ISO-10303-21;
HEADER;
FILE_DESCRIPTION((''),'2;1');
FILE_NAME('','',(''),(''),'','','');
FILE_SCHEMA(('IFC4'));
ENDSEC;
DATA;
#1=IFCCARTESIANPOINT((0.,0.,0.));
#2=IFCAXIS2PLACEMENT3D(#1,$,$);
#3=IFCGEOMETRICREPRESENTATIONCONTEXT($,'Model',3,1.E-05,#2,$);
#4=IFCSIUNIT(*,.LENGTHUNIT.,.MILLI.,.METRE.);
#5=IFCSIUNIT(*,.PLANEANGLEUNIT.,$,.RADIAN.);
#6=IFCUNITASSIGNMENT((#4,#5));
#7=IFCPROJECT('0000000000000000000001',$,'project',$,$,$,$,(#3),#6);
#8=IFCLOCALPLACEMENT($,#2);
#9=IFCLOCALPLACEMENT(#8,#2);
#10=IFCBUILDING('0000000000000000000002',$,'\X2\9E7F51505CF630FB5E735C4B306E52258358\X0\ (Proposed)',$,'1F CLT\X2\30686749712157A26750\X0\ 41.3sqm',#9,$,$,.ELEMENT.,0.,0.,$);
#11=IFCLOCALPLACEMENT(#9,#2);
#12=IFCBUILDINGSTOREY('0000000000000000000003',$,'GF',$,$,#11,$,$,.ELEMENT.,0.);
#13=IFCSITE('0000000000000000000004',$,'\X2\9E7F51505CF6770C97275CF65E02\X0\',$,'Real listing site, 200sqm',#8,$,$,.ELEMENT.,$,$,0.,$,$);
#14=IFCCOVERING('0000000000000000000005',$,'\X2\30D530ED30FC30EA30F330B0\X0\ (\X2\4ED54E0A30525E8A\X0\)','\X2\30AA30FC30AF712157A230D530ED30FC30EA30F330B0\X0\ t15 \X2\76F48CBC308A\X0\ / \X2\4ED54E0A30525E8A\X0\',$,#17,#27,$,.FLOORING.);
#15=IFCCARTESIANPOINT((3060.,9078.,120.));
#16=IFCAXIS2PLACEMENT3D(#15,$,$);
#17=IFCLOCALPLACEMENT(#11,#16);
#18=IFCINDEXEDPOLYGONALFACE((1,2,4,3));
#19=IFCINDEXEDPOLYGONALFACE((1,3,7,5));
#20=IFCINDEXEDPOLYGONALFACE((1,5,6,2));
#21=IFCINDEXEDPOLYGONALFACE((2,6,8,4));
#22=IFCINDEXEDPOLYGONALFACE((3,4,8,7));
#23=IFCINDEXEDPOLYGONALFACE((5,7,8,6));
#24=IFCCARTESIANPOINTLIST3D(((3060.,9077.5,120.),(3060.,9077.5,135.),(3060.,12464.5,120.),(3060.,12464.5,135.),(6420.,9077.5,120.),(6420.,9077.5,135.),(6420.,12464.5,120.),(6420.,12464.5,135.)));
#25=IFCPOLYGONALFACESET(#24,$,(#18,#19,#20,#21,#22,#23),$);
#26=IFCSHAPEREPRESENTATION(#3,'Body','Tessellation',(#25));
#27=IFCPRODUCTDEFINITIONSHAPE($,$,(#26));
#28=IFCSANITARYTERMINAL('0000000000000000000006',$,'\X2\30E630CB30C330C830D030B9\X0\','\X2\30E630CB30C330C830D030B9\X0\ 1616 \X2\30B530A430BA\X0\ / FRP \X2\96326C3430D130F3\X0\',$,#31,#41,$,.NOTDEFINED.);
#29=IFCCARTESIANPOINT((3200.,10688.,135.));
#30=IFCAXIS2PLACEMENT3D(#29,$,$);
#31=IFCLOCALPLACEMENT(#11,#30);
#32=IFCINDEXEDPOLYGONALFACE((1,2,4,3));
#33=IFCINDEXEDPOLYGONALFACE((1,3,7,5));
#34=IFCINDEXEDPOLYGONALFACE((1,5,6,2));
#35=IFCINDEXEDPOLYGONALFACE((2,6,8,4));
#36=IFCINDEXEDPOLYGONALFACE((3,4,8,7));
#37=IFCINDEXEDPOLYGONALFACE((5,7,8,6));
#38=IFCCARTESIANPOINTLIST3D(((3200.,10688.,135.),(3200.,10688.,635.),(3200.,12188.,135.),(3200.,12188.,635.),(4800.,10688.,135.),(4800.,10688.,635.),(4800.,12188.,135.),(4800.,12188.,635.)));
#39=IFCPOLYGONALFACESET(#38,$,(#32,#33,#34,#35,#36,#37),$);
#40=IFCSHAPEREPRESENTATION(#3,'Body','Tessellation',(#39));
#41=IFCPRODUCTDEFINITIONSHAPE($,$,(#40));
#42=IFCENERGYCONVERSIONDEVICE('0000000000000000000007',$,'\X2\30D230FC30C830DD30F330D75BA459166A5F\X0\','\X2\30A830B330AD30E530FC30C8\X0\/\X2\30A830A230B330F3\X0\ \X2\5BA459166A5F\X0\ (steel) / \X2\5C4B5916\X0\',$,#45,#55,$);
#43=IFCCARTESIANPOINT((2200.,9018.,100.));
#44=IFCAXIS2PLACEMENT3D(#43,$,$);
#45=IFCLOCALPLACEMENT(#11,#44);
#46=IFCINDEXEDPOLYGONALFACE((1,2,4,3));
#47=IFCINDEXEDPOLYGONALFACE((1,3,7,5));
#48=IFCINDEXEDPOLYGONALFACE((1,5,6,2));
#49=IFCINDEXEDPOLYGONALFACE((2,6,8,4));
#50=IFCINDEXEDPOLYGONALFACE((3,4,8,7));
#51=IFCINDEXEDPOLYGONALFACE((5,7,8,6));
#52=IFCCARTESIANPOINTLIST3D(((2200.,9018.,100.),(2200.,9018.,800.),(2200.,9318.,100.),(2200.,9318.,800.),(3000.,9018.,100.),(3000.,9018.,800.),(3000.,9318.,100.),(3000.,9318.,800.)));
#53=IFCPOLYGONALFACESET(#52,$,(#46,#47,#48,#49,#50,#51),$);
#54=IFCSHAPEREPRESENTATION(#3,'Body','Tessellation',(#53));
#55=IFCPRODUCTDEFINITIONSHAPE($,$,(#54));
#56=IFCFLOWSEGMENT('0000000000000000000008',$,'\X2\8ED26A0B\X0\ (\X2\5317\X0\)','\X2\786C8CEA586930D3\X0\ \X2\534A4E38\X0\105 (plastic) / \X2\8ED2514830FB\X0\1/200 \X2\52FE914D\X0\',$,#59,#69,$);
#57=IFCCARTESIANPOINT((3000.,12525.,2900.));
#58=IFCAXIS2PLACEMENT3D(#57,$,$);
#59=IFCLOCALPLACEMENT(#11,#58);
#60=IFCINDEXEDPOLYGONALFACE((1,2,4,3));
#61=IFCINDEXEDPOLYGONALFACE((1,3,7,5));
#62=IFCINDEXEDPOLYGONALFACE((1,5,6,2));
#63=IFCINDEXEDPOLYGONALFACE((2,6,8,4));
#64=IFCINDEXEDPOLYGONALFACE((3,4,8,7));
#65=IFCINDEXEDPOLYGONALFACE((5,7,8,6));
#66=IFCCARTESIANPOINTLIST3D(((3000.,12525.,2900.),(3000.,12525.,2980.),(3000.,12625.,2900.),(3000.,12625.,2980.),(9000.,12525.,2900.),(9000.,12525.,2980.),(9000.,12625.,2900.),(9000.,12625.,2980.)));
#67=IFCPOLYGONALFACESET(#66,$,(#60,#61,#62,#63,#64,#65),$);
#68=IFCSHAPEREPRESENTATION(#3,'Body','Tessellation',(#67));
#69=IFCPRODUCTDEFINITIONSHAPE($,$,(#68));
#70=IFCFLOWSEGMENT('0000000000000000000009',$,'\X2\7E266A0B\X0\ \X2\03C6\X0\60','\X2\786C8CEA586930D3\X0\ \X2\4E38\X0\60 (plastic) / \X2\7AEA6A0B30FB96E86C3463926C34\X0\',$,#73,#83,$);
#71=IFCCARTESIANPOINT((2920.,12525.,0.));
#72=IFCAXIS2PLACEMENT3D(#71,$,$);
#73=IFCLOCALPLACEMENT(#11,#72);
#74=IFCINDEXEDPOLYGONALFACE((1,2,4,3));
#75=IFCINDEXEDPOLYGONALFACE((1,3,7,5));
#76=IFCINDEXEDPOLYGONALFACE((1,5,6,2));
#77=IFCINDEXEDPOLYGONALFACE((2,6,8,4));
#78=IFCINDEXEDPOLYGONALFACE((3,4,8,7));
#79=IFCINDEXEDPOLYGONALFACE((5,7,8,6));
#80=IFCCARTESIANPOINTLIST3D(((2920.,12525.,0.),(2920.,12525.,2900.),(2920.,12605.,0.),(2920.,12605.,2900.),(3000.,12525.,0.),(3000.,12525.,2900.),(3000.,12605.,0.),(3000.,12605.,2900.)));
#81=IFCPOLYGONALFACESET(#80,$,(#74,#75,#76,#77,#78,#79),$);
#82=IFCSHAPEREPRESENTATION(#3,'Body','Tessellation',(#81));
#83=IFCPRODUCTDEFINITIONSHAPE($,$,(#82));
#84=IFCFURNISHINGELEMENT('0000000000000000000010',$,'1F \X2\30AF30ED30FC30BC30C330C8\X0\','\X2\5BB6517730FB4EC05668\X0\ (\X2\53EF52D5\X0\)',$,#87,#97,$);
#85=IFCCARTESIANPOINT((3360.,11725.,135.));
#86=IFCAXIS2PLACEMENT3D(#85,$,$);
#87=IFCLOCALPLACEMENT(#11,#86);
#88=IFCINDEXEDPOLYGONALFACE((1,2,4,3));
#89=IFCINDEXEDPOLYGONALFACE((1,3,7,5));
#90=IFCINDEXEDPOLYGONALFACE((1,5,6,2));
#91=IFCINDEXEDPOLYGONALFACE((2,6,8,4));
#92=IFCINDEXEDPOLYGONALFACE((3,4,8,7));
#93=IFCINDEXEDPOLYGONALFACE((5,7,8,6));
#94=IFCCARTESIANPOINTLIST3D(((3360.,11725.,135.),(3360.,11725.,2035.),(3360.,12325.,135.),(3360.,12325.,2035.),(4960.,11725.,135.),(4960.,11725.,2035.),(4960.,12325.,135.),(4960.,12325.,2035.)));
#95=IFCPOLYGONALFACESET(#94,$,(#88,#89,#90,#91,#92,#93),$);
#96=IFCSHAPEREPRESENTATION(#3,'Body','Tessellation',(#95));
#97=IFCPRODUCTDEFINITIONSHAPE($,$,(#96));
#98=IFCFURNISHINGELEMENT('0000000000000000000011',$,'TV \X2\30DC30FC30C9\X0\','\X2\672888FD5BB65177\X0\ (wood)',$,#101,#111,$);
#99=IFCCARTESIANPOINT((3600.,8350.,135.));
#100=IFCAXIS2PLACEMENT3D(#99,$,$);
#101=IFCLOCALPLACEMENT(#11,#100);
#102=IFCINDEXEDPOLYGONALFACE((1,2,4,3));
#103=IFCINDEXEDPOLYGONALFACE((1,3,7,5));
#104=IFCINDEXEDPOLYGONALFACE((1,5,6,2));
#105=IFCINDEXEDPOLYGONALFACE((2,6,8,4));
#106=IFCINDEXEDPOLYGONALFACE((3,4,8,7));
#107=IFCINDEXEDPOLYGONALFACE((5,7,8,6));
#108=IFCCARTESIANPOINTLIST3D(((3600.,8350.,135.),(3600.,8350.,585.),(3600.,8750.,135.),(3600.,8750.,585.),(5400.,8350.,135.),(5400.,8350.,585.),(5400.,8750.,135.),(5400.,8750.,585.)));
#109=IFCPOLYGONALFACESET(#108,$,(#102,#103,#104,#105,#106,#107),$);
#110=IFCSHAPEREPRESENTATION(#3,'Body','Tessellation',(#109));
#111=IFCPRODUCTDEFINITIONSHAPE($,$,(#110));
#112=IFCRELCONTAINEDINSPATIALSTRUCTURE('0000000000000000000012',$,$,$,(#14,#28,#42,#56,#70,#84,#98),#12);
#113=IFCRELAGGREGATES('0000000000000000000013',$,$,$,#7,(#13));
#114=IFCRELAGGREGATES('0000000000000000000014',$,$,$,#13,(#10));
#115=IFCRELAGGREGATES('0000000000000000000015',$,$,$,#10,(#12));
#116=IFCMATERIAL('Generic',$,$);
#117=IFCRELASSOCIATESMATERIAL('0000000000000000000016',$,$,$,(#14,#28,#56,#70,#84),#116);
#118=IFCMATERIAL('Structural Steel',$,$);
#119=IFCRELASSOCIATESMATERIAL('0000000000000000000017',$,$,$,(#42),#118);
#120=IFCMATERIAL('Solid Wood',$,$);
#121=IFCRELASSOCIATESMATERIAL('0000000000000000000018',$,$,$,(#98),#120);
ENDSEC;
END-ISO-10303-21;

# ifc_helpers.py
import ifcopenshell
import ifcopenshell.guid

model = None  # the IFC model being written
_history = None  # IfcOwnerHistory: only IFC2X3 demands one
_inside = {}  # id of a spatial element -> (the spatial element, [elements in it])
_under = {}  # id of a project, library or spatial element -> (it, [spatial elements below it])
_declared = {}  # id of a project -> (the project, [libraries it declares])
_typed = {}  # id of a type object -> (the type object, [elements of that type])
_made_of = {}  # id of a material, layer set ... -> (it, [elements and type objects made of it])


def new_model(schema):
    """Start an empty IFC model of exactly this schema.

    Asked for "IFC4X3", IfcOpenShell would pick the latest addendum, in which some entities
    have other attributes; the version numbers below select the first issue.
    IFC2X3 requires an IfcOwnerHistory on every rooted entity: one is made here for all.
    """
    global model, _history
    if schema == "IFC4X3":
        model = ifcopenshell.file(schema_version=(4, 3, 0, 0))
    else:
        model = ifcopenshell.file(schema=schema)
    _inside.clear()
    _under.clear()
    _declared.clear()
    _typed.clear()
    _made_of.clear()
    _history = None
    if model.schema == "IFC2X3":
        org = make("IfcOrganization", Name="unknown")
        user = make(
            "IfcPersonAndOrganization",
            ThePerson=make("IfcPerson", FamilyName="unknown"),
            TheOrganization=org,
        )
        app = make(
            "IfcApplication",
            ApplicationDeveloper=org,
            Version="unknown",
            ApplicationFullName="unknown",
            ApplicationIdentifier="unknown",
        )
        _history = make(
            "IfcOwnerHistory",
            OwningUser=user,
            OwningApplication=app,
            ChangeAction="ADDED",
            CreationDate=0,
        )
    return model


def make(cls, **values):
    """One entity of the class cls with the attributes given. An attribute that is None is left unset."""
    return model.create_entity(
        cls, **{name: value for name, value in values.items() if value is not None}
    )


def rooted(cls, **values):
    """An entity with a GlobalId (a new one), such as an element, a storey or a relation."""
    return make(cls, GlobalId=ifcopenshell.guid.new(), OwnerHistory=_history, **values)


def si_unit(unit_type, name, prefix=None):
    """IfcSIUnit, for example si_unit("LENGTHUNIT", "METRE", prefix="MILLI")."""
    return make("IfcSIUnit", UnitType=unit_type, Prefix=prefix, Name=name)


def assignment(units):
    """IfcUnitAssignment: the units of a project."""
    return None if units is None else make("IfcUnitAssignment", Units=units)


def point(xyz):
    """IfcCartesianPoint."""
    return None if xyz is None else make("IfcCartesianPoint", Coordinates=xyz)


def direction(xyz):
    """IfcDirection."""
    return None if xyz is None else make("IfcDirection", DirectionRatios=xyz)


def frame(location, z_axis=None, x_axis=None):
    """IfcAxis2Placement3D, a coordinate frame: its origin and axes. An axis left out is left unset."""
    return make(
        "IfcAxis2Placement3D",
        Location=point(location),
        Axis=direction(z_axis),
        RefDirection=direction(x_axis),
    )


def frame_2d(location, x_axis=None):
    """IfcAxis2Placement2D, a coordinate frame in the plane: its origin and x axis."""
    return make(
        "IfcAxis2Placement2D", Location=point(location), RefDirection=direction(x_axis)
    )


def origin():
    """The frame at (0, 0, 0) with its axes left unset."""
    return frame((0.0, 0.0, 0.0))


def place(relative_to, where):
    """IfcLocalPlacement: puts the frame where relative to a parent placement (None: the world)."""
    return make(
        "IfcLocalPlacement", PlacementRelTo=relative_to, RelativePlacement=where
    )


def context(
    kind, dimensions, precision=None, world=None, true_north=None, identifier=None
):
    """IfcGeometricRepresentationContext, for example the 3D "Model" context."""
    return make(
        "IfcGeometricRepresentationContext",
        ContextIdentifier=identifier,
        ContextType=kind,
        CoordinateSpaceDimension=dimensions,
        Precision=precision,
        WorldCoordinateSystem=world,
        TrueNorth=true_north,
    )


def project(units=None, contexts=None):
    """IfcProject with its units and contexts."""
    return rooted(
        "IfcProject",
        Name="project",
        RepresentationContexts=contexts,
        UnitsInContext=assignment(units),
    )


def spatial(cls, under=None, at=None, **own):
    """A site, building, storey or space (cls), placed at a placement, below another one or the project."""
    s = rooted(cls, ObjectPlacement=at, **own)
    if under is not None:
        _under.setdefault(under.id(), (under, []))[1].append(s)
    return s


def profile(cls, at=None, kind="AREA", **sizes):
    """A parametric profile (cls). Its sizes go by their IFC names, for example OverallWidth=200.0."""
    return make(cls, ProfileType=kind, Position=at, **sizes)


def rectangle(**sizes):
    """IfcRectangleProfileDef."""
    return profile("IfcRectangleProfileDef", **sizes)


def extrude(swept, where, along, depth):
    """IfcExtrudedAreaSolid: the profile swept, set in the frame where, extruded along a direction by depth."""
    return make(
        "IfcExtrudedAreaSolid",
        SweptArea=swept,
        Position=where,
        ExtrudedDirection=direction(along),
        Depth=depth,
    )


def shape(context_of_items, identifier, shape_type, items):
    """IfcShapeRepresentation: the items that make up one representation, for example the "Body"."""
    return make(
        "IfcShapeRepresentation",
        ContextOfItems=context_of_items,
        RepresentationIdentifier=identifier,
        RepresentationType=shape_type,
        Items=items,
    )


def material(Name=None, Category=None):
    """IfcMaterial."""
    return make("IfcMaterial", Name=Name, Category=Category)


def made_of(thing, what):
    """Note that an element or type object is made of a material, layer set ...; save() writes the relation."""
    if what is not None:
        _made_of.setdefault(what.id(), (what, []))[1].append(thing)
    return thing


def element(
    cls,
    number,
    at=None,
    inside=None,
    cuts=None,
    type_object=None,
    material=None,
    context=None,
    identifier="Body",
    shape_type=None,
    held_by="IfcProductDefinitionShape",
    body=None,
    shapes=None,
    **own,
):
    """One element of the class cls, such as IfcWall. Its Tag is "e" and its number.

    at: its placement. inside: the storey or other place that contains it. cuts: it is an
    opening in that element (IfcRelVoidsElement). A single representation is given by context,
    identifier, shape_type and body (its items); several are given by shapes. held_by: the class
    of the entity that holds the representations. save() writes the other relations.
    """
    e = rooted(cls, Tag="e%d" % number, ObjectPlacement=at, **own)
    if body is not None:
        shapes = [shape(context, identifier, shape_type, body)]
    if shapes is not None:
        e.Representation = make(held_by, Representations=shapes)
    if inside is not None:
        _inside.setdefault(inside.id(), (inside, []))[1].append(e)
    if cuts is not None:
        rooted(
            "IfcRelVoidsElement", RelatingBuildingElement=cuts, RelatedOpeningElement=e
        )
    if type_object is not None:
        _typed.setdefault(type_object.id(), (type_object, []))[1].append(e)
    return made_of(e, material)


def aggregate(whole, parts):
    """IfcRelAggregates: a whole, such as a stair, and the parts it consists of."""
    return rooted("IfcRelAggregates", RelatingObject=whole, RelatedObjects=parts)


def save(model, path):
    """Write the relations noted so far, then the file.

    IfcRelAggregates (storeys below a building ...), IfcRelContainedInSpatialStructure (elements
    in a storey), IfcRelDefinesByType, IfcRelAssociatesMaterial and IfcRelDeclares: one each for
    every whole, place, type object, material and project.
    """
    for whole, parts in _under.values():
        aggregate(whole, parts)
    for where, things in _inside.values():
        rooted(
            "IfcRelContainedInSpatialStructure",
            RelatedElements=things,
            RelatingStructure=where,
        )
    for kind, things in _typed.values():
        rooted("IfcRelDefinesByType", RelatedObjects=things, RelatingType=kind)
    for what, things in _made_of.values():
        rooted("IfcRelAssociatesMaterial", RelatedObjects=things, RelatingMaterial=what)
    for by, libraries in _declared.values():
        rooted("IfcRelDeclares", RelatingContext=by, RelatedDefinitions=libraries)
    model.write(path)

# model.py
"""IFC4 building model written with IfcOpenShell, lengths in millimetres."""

from ifc_helpers import new_model, si_unit, frame, frame_2d, origin, place, context, project, spatial, rectangle, extrude, material, element, save


model = new_model("IFC4")

# Units and contexts
model_context = context("Model", 3, precision=1e-05, world=origin())
ifc_project = project(units=[si_unit("LENGTHUNIT", "METRE", prefix="MILLI"), si_unit("PLANEANGLEUNIT", "RADIAN")], contexts=[model_context])

# Site, building, storey
site_placement = place(None, origin())
site = spatial("IfcSite", under=ifc_project, at=site_placement, Name="鹿児島県霧島市", ObjectType="Real listing site, 200sqm", CompositionType="ELEMENT", RefElevation=0.0)
building_placement = place(site_placement, origin())
building = spatial("IfcBuilding", under=site, at=building_placement, Name="鹿児島・平屋の別荘 (Proposed)", ObjectType="1F CLTと杉無垢材 41.3sqm", CompositionType="ELEMENT", ElevationOfRefHeight=0.0, ElevationOfTerrain=0.0)
storey_placement = place(building_placement, origin())
storey = spatial("IfcBuildingStorey", under=building, at=storey_placement, Name="GF", CompositionType="ELEMENT", Elevation=0.0)

# Shared definitions
ifc_material_1 = material(Name="Solid Wood")

# Shared definitions
ifc_material_2 = material(Name="Structural Steel")

# Covering
ifc_material_3 = material(Name="Generic")
covering_placement = place(storey_placement, frame((3060.0, 9078.0, 120.0)))
element("IfcCovering", 1, at=covering_placement, inside=storey, material=ifc_material_3, Name="フローリング (仕上げ床)", Description="オーク無垢フローリング t15 直貼り / 仕上げ床", PredefinedType="FLOORING", context=model_context, shape_type="SweptSolid", body=[
    extrude(rectangle(XDim=3360.0, YDim=3387.0, at=frame_2d((1680.0, 1693.0))), frame((3060.0, 9078.0, 120.0)), (0.0, 0.0, 1.0), 15.0),
])

# Sanitary terminal
sanitary_terminal_placement = place(storey_placement, frame((3200.0, 10688.0, 135.0)))
element("IfcSanitaryTerminal", 2, at=sanitary_terminal_placement, inside=storey, material=ifc_material_3, Name="ユニットバス", Description="ユニットバス 1616 サイズ / FRP 防水パン", PredefinedType="NOTDEFINED", context=model_context, shape_type="SweptSolid", body=[
    extrude(rectangle(XDim=1600.0, YDim=1500.0, at=frame_2d((800.0, 750.0))), frame((3200.0, 10688.0, 135.0)), (0.0, 0.0, 1.0), 500.0),
])

# Energy conversion device
energy_conversion_device_placement = place(storey_placement, frame((2200.0, 9018.0, 100.0)))
element("IfcEnergyConversionDevice", 3, at=energy_conversion_device_placement, inside=storey, material=ifc_material_2, Name="ヒートポンプ室外機", Description="エコキュート/エアコン 室外機 (steel) / 屋外", context=model_context, shape_type="SweptSolid", body=[
    extrude(rectangle(XDim=800.0, YDim=300.0, at=frame_2d((400.0, 150.0))), frame((2200.0, 9018.0, 100.0)), (0.0, 0.0, 1.0), 700.0),
])

# Flow segments
flow_segment_1_placement = place(storey_placement, frame((3000.0, 12525.0, 2900.0)))
element("IfcFlowSegment", 4, at=flow_segment_1_placement, inside=storey, material=ifc_material_3, Name="軒樋 (北)", Description="硬質塩ビ 半丸105 (plastic) / 軒先・1/200 勾配", context=model_context, shape_type="SweptSolid", body=[
    extrude(rectangle(XDim=6000.0, YDim=100.0, at=frame_2d((3000.0, 50.0))), frame((3000.0, 12525.0, 2900.0)), (0.0, 0.0, 1.0), 80.0),
])
flow_segment_2_placement = place(storey_placement, frame((2920.0, 12525.0, 0.0)))
element("IfcFlowSegment", 5, at=flow_segment_2_placement, inside=storey, material=ifc_material_3, Name="縦樋 φ60", Description="硬質塩ビ 丸60 (plastic) / 竪樋・雨水排水", context=model_context, shape_type="SweptSolid", body=[
    extrude(rectangle(XDim=80.0, YDim=80.0, at=frame_2d((40.0, 40.0))), frame((2920.0, 12525.0, 0.0)), (0.0, 0.0, 1.0), 2900.0),
])

# Furnishing elements
furnishing_1_placement = place(storey_placement, frame((3360.0, 11725.0, 135.0)))
element("IfcFurnishingElement", 6, at=furnishing_1_placement, inside=storey, material=ifc_material_3, Name="1F クローゼット", Description="家具・什器 (可動)", context=model_context, shape_type="SweptSolid", body=[
    extrude(rectangle(XDim=1600.0, YDim=600.0, at=frame_2d((800.0, 300.0))), frame((3360.0, 11725.0, 135.0)), (0.0, 0.0, 1.0), 1900.0),
])
furnishing_2_placement = place(storey_placement, frame((3600.0, 8350.0, 135.0)))
element("IfcFurnishingElement", 7, at=furnishing_2_placement, inside=storey, material=ifc_material_1, Name="TV ボード", Description="木製家具 (wood)", context=model_context, shape_type="SweptSolid", body=[
    extrude(rectangle(XDim=1800.0, YDim=400.0, at=frame_2d((900.0, 200.0))), frame((3600.0, 8350.0, 135.0)), (0.0, 0.0, 1.0), 450.0),
])

save(model, "model.ifc")
